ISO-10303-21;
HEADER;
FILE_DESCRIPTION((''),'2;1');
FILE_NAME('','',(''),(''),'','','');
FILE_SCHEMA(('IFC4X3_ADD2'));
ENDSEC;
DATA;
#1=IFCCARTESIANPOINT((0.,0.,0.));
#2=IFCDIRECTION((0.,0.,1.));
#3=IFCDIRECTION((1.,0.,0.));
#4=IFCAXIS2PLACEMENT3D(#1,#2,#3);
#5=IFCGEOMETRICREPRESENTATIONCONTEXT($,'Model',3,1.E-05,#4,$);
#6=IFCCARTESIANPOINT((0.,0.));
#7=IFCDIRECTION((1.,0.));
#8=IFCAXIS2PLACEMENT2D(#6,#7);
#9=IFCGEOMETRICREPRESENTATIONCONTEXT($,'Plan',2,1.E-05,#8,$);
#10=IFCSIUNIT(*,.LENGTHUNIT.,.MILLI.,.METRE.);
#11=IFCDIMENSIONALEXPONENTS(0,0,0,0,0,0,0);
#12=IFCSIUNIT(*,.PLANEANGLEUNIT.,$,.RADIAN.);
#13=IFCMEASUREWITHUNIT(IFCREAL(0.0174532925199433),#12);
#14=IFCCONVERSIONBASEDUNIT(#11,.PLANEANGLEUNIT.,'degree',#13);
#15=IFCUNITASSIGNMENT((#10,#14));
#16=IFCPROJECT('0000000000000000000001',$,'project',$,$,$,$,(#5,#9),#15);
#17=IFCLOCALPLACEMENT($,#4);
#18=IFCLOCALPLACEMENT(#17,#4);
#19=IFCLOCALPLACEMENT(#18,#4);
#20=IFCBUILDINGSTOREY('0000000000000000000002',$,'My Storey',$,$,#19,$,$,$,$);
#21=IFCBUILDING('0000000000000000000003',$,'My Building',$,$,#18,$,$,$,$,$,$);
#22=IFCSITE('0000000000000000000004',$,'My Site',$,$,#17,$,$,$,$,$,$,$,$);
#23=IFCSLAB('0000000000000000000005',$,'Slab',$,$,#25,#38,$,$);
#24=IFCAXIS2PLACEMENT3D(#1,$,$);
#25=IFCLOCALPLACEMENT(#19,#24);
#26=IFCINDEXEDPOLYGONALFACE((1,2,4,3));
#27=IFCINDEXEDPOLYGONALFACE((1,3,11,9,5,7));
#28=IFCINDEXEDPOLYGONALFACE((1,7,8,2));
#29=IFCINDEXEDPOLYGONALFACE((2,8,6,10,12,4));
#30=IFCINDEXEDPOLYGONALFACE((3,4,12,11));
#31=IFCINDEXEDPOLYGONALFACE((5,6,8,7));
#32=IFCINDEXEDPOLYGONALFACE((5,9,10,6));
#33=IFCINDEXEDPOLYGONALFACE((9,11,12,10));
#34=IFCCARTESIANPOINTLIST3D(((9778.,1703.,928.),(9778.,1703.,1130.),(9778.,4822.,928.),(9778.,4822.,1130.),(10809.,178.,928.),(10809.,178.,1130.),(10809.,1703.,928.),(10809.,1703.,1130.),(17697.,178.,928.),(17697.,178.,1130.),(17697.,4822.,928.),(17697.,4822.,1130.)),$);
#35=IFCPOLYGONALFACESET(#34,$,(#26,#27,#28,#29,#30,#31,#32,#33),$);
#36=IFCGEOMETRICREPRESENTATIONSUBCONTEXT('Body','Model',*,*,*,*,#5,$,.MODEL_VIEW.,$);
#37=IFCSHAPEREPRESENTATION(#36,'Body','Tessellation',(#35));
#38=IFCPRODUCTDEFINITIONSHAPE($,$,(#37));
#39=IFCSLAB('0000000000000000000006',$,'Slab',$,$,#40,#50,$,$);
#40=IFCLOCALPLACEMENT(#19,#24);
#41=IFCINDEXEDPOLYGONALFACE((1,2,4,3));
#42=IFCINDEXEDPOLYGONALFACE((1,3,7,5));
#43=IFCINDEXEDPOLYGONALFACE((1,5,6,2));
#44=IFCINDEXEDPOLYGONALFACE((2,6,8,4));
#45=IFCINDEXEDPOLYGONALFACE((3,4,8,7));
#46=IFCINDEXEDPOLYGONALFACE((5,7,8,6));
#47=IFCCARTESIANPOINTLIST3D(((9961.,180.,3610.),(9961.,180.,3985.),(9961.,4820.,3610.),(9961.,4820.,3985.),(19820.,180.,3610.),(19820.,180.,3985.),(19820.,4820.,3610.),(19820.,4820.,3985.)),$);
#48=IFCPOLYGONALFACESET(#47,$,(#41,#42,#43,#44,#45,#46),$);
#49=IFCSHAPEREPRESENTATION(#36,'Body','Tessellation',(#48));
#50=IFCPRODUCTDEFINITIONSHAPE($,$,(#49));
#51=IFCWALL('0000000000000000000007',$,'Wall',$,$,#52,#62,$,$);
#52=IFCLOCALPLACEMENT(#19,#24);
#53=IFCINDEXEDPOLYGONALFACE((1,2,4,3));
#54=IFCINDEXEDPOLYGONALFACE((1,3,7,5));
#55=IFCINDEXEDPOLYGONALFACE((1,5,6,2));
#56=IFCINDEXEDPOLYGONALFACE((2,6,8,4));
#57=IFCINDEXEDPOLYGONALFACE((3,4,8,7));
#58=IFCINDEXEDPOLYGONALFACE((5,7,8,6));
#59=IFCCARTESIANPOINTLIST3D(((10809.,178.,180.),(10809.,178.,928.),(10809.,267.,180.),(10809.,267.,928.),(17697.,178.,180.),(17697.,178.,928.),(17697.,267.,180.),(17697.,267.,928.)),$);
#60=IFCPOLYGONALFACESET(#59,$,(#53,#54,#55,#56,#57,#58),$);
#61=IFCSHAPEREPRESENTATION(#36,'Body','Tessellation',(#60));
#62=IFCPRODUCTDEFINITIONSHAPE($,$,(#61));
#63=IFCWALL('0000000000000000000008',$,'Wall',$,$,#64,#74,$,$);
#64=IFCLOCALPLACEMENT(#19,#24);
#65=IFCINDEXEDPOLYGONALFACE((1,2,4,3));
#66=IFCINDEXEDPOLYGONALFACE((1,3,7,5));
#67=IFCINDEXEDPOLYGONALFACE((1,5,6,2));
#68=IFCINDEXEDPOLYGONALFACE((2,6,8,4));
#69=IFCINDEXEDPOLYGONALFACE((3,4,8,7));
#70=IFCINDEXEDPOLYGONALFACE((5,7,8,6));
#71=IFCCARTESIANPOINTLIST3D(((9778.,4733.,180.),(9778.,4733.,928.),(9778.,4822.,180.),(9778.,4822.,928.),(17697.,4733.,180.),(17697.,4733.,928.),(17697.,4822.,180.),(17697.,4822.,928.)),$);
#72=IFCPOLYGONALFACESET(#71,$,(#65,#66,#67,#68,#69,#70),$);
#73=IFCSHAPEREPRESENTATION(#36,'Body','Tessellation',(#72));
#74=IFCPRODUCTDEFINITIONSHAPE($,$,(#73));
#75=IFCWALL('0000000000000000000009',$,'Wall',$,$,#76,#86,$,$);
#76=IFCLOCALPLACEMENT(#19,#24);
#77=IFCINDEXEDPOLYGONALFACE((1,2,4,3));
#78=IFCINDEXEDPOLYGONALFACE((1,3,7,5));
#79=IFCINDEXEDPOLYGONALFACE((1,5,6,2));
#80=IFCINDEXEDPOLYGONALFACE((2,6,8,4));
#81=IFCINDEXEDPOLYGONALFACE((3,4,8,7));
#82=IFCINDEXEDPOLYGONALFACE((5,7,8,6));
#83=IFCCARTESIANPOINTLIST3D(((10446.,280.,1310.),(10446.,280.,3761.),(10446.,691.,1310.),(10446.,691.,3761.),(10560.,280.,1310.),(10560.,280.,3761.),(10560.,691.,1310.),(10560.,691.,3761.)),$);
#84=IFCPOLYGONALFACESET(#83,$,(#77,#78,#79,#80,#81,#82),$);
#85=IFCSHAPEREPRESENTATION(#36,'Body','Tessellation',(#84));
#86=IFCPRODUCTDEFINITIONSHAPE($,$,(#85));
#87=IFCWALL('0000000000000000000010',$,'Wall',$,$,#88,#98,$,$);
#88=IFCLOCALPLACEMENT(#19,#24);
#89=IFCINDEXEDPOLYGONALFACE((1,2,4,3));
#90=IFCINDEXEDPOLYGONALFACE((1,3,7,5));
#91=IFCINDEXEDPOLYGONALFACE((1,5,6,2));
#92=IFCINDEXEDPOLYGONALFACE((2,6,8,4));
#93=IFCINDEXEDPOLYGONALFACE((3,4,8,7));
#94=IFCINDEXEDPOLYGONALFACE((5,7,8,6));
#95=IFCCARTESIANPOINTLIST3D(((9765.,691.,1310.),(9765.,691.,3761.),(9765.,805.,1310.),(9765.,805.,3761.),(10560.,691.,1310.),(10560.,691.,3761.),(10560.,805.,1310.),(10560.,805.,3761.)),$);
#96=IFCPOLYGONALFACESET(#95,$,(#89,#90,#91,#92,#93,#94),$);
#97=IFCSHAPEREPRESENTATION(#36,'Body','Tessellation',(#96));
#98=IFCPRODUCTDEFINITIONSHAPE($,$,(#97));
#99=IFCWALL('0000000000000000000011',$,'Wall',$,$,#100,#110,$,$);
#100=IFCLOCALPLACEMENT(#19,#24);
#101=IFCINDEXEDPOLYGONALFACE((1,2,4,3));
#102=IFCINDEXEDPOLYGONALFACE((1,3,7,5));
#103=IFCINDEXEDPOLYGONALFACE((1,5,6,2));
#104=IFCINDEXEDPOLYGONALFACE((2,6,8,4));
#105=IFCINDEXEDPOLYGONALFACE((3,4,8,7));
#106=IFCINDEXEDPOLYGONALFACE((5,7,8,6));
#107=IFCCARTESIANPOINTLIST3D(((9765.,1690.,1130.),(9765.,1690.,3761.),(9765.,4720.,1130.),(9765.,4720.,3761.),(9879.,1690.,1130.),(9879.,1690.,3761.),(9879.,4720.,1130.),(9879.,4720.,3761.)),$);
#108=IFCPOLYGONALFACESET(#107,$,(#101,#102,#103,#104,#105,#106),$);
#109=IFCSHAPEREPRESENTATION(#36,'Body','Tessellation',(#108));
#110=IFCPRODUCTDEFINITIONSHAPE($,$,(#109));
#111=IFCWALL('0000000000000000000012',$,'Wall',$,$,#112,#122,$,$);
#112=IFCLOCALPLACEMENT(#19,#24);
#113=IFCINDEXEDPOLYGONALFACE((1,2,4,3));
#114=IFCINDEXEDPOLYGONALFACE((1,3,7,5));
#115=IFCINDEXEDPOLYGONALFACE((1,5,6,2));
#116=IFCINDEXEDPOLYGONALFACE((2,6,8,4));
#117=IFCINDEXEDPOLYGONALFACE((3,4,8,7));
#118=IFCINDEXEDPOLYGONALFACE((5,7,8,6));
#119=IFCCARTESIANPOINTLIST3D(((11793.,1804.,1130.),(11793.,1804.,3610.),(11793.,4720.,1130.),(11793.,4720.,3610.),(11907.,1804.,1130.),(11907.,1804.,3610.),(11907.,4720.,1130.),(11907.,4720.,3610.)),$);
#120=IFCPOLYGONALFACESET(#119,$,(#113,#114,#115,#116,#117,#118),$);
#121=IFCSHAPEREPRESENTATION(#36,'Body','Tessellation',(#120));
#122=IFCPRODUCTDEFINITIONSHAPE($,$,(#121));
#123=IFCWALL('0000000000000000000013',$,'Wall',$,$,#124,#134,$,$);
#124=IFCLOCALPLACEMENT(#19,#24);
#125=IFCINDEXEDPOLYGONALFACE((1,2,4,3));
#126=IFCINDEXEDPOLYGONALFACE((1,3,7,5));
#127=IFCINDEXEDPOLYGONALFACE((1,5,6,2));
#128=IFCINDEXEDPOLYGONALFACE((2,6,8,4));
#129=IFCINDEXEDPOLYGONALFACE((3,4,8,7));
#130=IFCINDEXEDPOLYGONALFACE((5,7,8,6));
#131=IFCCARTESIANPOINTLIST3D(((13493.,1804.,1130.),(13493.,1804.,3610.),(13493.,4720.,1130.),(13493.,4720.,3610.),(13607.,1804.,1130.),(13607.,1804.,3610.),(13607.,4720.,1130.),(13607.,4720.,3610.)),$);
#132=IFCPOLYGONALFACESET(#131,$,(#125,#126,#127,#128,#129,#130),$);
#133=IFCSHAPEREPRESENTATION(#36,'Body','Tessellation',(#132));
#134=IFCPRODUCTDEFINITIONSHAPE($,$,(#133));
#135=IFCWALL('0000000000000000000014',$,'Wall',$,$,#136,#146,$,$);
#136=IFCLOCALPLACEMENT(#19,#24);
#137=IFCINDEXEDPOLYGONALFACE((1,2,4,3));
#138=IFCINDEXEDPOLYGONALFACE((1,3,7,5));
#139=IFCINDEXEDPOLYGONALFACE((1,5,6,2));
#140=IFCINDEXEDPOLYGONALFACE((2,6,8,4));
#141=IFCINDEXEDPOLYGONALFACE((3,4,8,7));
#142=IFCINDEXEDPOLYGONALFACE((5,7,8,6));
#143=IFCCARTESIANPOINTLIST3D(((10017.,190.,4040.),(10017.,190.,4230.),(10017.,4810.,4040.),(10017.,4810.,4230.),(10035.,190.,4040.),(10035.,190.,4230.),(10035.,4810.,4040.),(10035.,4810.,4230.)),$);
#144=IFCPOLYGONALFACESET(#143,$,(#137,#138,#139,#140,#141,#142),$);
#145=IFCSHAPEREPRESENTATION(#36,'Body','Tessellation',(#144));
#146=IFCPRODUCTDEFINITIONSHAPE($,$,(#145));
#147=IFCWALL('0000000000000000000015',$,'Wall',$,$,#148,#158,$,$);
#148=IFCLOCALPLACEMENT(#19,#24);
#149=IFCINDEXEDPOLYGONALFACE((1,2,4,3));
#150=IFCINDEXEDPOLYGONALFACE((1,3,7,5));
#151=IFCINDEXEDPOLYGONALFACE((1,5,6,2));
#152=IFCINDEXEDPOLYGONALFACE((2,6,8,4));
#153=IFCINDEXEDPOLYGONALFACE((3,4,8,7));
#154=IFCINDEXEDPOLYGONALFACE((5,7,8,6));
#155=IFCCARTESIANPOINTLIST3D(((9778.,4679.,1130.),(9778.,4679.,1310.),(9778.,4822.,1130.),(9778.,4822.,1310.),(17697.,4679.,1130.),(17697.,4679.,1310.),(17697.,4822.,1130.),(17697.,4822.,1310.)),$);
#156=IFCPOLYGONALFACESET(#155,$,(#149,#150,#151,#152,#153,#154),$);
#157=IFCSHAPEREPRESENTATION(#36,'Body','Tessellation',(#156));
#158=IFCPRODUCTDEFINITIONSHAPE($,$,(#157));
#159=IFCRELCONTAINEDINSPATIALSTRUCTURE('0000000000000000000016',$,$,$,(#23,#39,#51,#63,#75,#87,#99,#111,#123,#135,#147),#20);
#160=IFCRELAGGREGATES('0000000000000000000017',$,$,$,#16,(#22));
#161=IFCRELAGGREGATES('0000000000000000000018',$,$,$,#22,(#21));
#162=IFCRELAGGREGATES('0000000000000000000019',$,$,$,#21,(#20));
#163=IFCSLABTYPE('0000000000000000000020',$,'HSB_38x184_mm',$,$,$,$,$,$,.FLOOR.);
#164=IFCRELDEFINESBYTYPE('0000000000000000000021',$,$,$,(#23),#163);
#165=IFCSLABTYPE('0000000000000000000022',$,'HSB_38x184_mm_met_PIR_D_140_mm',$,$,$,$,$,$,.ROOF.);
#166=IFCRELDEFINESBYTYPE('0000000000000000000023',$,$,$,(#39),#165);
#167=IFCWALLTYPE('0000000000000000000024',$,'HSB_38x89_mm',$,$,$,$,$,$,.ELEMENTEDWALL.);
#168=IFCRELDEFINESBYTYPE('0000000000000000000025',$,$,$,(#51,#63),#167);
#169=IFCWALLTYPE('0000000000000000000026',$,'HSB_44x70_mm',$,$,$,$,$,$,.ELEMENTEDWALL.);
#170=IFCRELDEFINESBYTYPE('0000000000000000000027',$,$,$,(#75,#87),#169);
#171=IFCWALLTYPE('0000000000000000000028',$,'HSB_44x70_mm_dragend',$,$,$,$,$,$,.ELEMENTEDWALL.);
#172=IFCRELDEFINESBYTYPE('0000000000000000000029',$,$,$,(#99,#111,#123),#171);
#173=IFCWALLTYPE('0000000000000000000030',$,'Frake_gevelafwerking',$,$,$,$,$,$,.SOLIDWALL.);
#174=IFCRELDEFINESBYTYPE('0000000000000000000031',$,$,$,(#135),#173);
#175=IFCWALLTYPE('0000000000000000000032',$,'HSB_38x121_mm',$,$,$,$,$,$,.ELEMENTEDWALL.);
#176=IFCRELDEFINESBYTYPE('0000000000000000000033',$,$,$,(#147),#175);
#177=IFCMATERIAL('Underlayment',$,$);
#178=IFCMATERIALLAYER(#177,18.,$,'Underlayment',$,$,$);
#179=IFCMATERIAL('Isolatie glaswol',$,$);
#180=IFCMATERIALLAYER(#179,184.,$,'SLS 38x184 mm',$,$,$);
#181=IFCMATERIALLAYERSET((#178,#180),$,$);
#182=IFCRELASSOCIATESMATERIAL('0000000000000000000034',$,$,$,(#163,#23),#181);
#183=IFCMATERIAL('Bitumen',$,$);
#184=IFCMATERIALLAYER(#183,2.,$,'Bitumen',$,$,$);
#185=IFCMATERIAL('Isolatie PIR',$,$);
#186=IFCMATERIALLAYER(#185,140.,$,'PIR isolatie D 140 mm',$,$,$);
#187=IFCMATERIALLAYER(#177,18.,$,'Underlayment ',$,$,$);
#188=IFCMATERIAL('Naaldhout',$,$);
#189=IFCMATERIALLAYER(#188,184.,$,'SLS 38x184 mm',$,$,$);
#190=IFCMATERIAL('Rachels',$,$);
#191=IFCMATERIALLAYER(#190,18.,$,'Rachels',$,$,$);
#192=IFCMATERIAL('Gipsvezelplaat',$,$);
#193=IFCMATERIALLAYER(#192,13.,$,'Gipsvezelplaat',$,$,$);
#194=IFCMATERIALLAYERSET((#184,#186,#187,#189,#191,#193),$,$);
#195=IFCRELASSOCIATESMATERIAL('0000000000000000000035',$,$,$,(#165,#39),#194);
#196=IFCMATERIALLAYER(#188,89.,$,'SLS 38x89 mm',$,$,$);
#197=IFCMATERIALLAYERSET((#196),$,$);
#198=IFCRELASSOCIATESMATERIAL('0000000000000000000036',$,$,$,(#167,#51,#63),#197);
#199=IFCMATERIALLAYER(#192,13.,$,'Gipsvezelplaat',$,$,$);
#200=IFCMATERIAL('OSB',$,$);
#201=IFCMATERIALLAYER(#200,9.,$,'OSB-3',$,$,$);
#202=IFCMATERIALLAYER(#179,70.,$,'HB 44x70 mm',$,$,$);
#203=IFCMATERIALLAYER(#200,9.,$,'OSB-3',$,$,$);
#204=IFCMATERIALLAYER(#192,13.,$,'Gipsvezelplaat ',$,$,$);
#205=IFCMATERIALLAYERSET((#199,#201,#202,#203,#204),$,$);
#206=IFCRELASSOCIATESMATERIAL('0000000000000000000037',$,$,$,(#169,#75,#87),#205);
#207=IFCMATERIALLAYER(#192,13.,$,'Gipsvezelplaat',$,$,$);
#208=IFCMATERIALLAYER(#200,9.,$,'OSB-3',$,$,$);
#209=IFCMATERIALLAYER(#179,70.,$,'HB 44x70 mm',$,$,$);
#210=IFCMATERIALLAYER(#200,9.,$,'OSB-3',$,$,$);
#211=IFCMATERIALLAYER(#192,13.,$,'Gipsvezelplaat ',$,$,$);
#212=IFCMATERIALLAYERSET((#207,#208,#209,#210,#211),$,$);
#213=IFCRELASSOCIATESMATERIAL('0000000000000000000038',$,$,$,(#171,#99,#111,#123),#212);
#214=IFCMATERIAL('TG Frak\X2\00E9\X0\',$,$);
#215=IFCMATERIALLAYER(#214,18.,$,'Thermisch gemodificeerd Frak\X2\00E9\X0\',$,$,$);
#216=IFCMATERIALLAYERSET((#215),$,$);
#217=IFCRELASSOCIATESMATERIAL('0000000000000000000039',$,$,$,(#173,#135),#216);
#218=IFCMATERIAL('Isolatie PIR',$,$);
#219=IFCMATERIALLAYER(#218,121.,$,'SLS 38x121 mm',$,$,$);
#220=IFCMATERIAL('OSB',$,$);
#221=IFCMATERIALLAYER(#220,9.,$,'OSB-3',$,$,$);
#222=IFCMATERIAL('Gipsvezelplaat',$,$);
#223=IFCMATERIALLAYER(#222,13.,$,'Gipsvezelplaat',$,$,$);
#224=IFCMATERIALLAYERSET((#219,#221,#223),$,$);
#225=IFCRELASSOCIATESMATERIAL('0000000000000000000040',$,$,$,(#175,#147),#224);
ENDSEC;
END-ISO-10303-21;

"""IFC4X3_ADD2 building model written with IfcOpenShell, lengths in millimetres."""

from ifc_helpers import new_model, entity, si_unit, converted_unit, frame, origin_with_axes, origin_2d_with_axis, place, context, subcontext, project, spatial, line, indexed_curve, outline, extrude, material, layer, layer_set, layer_usage, type_object, element, save


model = new_model("IFC4X3_ADD2")

# Units and contexts
model_context = context("Model", 3, precision=1e-05, world=origin_with_axes())
plan_context = context("Plan", 2, precision=1e-05, world=origin_2d_with_axis())
body_context_1 = subcontext(model_context, "Body", "Model", "MODEL_VIEW")
ifc_project = project(units=[si_unit("LENGTHUNIT", "METRE", prefix="MILLI"), converted_unit("PLANEANGLEUNIT", "degree", entity("IfcReal", 0.0174532925199433), si_unit("PLANEANGLEUNIT", "RADIAN"), dimensions=[0, 0, 0, 0, 0, 0, 0])], contexts=[model_context, plan_context])

# Site, building, storey
site_placement = place(None, origin_with_axes())
site = spatial("IfcSite", under=ifc_project, at=site_placement, Name="My Site")
building_placement = place(site_placement, origin_with_axes())
building = spatial("IfcBuilding", under=site, at=building_placement, Name="My Building")
storey_placement = place(building_placement, origin_with_axes())
storey = spatial("IfcBuildingStorey", under=building, at=storey_placement, Name="My Storey")

# Slabs
ifc_material_1 = material(Name="Underlayment")
ifc_layer_1 = layer(ifc_material_1, 18.0, Name="Underlayment")
ifc_material_2 = material(Name="Isolatie glaswol")
ifc_layer_2 = layer(ifc_material_2, 184.0, Name="SLS 38x184 mm")
ifc_layer_set_1 = layer_set([ifc_layer_1, ifc_layer_2])
ifc_layer_usage_1 = layer_usage(ifc_layer_set_1, "AXIS3", "POSITIVE", 0.0)
slab_type_1 = type_object("IfcSlabType", Name="HSB_38x184_mm", PredefinedType="FLOOR", material=ifc_layer_set_1)
slab_1_placement = place(storey_placement, frame((10809.0, 178.0, 928.0), z_axis=(0.0, 0.0, 1.0), x_axis=(1.0, 0.0, 0.0)))
element("IfcSlab", 1, at=slab_1_placement, inside=storey, type_object=slab_type_1, material=ifc_layer_usage_1, Name="Slab", context=body_context_1, shape_type="SweptSolid", body=[
    extrude(outline(indexed_curve([(-1031.0, 1525.0), (-1031.0, 4644.0), (6888.0, 4644.0), (6888.0, 0.0), (0.0, 0.0), (0.0, 1525.0)], segments=[line(1, 6), line(6, 5), line(5, 4), line(4, 3), line(3, 2), line(2, 1)], self_intersect=False)), None, (0.0, 0.0, 1.0), 202.0),
])
ifc_material_3 = material(Name="Bitumen")
ifc_layer_3 = layer(ifc_material_3, 2.0, Name="Bitumen")
ifc_material_4 = material(Name="Isolatie PIR")
ifc_layer_4 = layer(ifc_material_4, 140.0, Name="PIR isolatie D 140 mm")
ifc_layer_5 = layer(ifc_material_1, 18.0, Name="Underlayment ")
ifc_material_5 = material(Name="Naaldhout")
ifc_layer_6 = layer(ifc_material_5, 184.0, Name="SLS 38x184 mm")
ifc_material_6 = material(Name="Rachels")
ifc_layer_7 = layer(ifc_material_6, 18.0, Name="Rachels")
ifc_material_7 = material(Name="Gipsvezelplaat")
ifc_layer_8 = layer(ifc_material_7, 13.0, Name="Gipsvezelplaat")
ifc_layer_set_2 = layer_set([ifc_layer_3, ifc_layer_4, ifc_layer_5, ifc_layer_6, ifc_layer_7, ifc_layer_8])
ifc_layer_usage_2 = layer_usage(ifc_layer_set_2, "AXIS3", "POSITIVE", 0.0)
slab_type_2 = type_object("IfcSlabType", Name="HSB_38x184_mm_met_PIR_D_140_mm", PredefinedType="ROOF", material=ifc_layer_set_2)
slab_2_placement = place(storey_placement, frame((9961.0, 180.0, 3610.0), z_axis=(0.0, 0.0, 1.0), x_axis=(1.0, 0.0, 0.0)))
element("IfcSlab", 2, at=slab_2_placement, inside=storey, type_object=slab_type_2, material=ifc_layer_usage_2, Name="Slab", context=body_context_1, shape_type="SweptSolid", body=[
    extrude(outline(indexed_curve([(0.0, 0.0), (9859.0, 0.0), (9859.0, 4640.0), (0.0, 4640.0)], segments=[line(3, 2), line(2, 1), line(1, 4), line(4, 3)], self_intersect=False)), None, (0.0, 0.0, 1.0), 375.0),
])

# Walls
ifc_layer_9 = layer(ifc_material_5, 89.0, Name="SLS 38x89 mm")
ifc_layer_set_3 = layer_set([ifc_layer_9])
ifc_layer_usage_3 = layer_usage(ifc_layer_set_3, "AXIS2", "POSITIVE", 0.0)
wall_type_1 = type_object("IfcWallType", Name="HSB_38x89_mm", PredefinedType="ELEMENTEDWALL", material=ifc_layer_set_3)
wall_1_placement = place(storey_placement, frame((10809.0, 178.0, 180.0), z_axis=(0.0, 0.0, 1.0), x_axis=(1.0, 0.0, 0.0)))
element("IfcWall", 3, at=wall_1_placement, inside=storey, type_object=wall_type_1, material=ifc_layer_usage_3, Name="Wall", context=body_context_1, shape_type="SweptSolid", body=[
    extrude(outline(indexed_curve([(0.0, 0.0), (0.0, 89.0), (6888.0, 89.0), (6888.0, 0.0), (0.0, 0.0)], self_intersect=False)), origin_with_axes(), (0.0, 0.0, 1.0), 748.0),
])
ifc_layer_usage_4 = layer_usage(ifc_layer_set_3, "AXIS2", "POSITIVE", 0.0)
wall_2_placement = place(storey_placement, frame((9778.0, 4733.0, 180.0), z_axis=(0.0, 0.0, 1.0), x_axis=(1.0, 0.0, 0.0)))
element("IfcWall", 4, at=wall_2_placement, inside=storey, type_object=wall_type_1, material=ifc_layer_usage_4, Name="Wall", context=body_context_1, shape_type="SweptSolid", body=[
    extrude(outline(indexed_curve([(0.0, 0.0), (0.0, 89.0), (7919.0, 89.0), (7919.0, 0.0), (0.0, 0.0)], self_intersect=False)), origin_with_axes(), (0.0, 0.0, 1.0), 748.0),
])

# Shared definitions
ifc_layer_10 = layer(ifc_material_7, 13.0, Name="Gipsvezelplaat")
ifc_material_8 = material(Name="OSB")
ifc_layer_11 = layer(ifc_material_8, 9.0, Name="OSB-3")
ifc_layer_12 = layer(ifc_material_2, 70.0, Name="HB 44x70 mm")
ifc_layer_13 = layer(ifc_material_8, 9.0, Name="OSB-3")
ifc_layer_14 = layer(ifc_material_7, 13.0, Name="Gipsvezelplaat ")
ifc_layer_set_4 = layer_set([ifc_layer_10, ifc_layer_11, ifc_layer_12, ifc_layer_13, ifc_layer_14])
wall_type_2 = type_object("IfcWallType", Name="HSB_44x70_mm", PredefinedType="ELEMENTEDWALL", material=ifc_layer_set_4)

# Walls
ifc_layer_usage_5 = layer_usage(ifc_layer_set_4, "AXIS2", "POSITIVE", 0.0)
wall_3_placement = place(storey_placement, frame((10560.0, 280.0, 1310.0), z_axis=(0.0, 0.0, 1.0), x_axis=(0.0, 1.0, 0.0)))
element("IfcWall", 5, at=wall_3_placement, inside=storey, type_object=wall_type_2, material=ifc_layer_usage_5, Name="Wall", context=body_context_1, shape_type="SweptSolid", body=[
    extrude(outline(indexed_curve([(0.0, 0.0), (0.0, 114.0), (411.0, 114.0), (411.0, 0.0), (0.0, 0.0)], self_intersect=False)), origin_with_axes(), (0.0, 0.0, 1.0), 2451.0),
])
ifc_layer_usage_6 = layer_usage(ifc_layer_set_4, "AXIS2", "POSITIVE", 0.0)
wall_4_placement = place(storey_placement, frame((9765.0, 691.0, 1310.0), z_axis=(0.0, 0.0, 1.0), x_axis=(1.0, 0.0, 0.0)))
element("IfcWall", 6, at=wall_4_placement, inside=storey, type_object=wall_type_2, material=ifc_layer_usage_6, Name="Wall", context=body_context_1, shape_type="SweptSolid", body=[
    extrude(outline(indexed_curve([(0.0, 0.0), (0.0, 114.0), (795.0, 114.0), (795.0, 0.0), (0.0, 0.0)], self_intersect=False)), origin_with_axes(), (0.0, 0.0, 1.0), 2451.0),
])
ifc_layer_15 = layer(ifc_material_7, 13.0, Name="Gipsvezelplaat")
ifc_layer_16 = layer(ifc_material_8, 9.0, Name="OSB-3")
ifc_layer_17 = layer(ifc_material_2, 70.0, Name="HB 44x70 mm")
ifc_layer_18 = layer(ifc_material_8, 9.0, Name="OSB-3")
ifc_layer_19 = layer(ifc_material_7, 13.0, Name="Gipsvezelplaat ")
ifc_layer_set_5 = layer_set([ifc_layer_15, ifc_layer_16, ifc_layer_17, ifc_layer_18, ifc_layer_19])
ifc_layer_usage_7 = layer_usage(ifc_layer_set_5, "AXIS2", "POSITIVE", 0.0)
wall_type_3 = type_object("IfcWallType", Name="HSB_44x70_mm_dragend", PredefinedType="ELEMENTEDWALL", material=ifc_layer_set_5)
wall_5_placement = place(storey_placement, frame((9879.0, 1690.0, 1130.0), z_axis=(0.0, 0.0, 1.0), x_axis=(0.0, 1.0, 0.0)))
element("IfcWall", 7, at=wall_5_placement, inside=storey, type_object=wall_type_3, material=ifc_layer_usage_7, Name="Wall", context=body_context_1, shape_type="SweptSolid", body=[
    extrude(outline(indexed_curve([(0.0, 0.0), (0.0, 114.0), (3030.0, 114.0), (3030.0, 0.0), (0.0, 0.0)], self_intersect=False)), origin_with_axes(), (0.0, 0.0, 1.0), 2631.0),
])
ifc_layer_usage_8 = layer_usage(ifc_layer_set_5, "AXIS2", "POSITIVE", 0.0)
wall_6_placement = place(storey_placement, frame((11907.0, 1804.0, 1130.0), z_axis=(0.0, 0.0, 1.0), x_axis=(0.0, 1.0, 0.0)))
element("IfcWall", 8, at=wall_6_placement, inside=storey, type_object=wall_type_3, material=ifc_layer_usage_8, Name="Wall", context=body_context_1, shape_type="SweptSolid", body=[
    extrude(outline(indexed_curve([(0.0, 0.0), (0.0, 114.0), (2916.0, 114.0), (2916.0, 0.0), (0.0, 0.0)], self_intersect=False)), origin_with_axes(), (0.0, 0.0, 1.0), 2480.0),
])
ifc_layer_usage_9 = layer_usage(ifc_layer_set_5, "AXIS2", "POSITIVE", 0.0)
wall_7_placement = place(storey_placement, frame((13607.0, 1804.0, 1130.0), z_axis=(0.0, 0.0, 1.0), x_axis=(0.0, 1.0, 0.0)))
element("IfcWall", 9, at=wall_7_placement, inside=storey, type_object=wall_type_3, material=ifc_layer_usage_9, Name="Wall", context=body_context_1, shape_type="SweptSolid", body=[
    extrude(outline(indexed_curve([(0.0, 0.0), (0.0, 114.0), (2916.0, 114.0), (2916.0, 0.0), (0.0, 0.0)], self_intersect=False)), origin_with_axes(), (0.0, 0.0, 1.0), 2480.0),
])
ifc_material_9 = material(Name="TG Fraké")
ifc_layer_20 = layer(ifc_material_9, 18.0, Name="Thermisch gemodificeerd Fraké")
ifc_layer_set_6 = layer_set([ifc_layer_20])
ifc_layer_usage_10 = layer_usage(ifc_layer_set_6, "AXIS2", "POSITIVE", 0.0)
wall_type_4 = type_object("IfcWallType", Name="Frake_gevelafwerking", PredefinedType="SOLIDWALL", material=ifc_layer_set_6)
wall_8_placement = place(storey_placement, frame((10035.0, 190.0, 4040.0), z_axis=(0.0, 0.0, 1.0), x_axis=(0.0, 1.0, 0.0)))
element("IfcWall", 10, at=wall_8_placement, inside=storey, type_object=wall_type_4, material=ifc_layer_usage_10, Name="Wall", context=body_context_1, shape_type="SweptSolid", body=[
    extrude(outline(indexed_curve([(0.0, 0.0), (0.0, 18.0), (4620.0, 18.0), (4620.0, 0.0), (0.0, 0.0)], self_intersect=False)), origin_with_axes(), (0.0, 0.0, 1.0), 190.0),
])
ifc_material_10 = material(Name="Isolatie PIR")
ifc_layer_21 = layer(ifc_material_10, 121.0, Name="SLS 38x121 mm")
ifc_material_11 = material(Name="OSB")
ifc_layer_22 = layer(ifc_material_11, 9.0, Name="OSB-3")
ifc_material_12 = material(Name="Gipsvezelplaat")
ifc_layer_23 = layer(ifc_material_12, 13.0, Name="Gipsvezelplaat")
ifc_layer_set_7 = layer_set([ifc_layer_21, ifc_layer_22, ifc_layer_23])
ifc_layer_usage_11 = layer_usage(ifc_layer_set_7, "AXIS2", "POSITIVE", 0.0)
wall_type_5 = type_object("IfcWallType", Name="HSB_38x121_mm", PredefinedType="ELEMENTEDWALL", material=ifc_layer_set_7)
wall_9_placement = place(storey_placement, frame((9778.0, 4679.0, 1130.0), z_axis=(0.0, 0.0, 1.0), x_axis=(1.0, 0.0, 0.0)))
element("IfcWall", 11, at=wall_9_placement, inside=storey, type_object=wall_type_5, material=ifc_layer_usage_11, Name="Wall", context=body_context_1, shape_type="SweptSolid", body=[
    extrude(outline(indexed_curve([(0.0, 0.0), (0.0, 143.0), (7919.0, 143.0), (7919.0, 0.0), (0.0, 0.0)], self_intersect=False)), origin_with_axes(), (0.0, 0.0, 1.0), 180.0),
])

save(model, "model.ifc")
